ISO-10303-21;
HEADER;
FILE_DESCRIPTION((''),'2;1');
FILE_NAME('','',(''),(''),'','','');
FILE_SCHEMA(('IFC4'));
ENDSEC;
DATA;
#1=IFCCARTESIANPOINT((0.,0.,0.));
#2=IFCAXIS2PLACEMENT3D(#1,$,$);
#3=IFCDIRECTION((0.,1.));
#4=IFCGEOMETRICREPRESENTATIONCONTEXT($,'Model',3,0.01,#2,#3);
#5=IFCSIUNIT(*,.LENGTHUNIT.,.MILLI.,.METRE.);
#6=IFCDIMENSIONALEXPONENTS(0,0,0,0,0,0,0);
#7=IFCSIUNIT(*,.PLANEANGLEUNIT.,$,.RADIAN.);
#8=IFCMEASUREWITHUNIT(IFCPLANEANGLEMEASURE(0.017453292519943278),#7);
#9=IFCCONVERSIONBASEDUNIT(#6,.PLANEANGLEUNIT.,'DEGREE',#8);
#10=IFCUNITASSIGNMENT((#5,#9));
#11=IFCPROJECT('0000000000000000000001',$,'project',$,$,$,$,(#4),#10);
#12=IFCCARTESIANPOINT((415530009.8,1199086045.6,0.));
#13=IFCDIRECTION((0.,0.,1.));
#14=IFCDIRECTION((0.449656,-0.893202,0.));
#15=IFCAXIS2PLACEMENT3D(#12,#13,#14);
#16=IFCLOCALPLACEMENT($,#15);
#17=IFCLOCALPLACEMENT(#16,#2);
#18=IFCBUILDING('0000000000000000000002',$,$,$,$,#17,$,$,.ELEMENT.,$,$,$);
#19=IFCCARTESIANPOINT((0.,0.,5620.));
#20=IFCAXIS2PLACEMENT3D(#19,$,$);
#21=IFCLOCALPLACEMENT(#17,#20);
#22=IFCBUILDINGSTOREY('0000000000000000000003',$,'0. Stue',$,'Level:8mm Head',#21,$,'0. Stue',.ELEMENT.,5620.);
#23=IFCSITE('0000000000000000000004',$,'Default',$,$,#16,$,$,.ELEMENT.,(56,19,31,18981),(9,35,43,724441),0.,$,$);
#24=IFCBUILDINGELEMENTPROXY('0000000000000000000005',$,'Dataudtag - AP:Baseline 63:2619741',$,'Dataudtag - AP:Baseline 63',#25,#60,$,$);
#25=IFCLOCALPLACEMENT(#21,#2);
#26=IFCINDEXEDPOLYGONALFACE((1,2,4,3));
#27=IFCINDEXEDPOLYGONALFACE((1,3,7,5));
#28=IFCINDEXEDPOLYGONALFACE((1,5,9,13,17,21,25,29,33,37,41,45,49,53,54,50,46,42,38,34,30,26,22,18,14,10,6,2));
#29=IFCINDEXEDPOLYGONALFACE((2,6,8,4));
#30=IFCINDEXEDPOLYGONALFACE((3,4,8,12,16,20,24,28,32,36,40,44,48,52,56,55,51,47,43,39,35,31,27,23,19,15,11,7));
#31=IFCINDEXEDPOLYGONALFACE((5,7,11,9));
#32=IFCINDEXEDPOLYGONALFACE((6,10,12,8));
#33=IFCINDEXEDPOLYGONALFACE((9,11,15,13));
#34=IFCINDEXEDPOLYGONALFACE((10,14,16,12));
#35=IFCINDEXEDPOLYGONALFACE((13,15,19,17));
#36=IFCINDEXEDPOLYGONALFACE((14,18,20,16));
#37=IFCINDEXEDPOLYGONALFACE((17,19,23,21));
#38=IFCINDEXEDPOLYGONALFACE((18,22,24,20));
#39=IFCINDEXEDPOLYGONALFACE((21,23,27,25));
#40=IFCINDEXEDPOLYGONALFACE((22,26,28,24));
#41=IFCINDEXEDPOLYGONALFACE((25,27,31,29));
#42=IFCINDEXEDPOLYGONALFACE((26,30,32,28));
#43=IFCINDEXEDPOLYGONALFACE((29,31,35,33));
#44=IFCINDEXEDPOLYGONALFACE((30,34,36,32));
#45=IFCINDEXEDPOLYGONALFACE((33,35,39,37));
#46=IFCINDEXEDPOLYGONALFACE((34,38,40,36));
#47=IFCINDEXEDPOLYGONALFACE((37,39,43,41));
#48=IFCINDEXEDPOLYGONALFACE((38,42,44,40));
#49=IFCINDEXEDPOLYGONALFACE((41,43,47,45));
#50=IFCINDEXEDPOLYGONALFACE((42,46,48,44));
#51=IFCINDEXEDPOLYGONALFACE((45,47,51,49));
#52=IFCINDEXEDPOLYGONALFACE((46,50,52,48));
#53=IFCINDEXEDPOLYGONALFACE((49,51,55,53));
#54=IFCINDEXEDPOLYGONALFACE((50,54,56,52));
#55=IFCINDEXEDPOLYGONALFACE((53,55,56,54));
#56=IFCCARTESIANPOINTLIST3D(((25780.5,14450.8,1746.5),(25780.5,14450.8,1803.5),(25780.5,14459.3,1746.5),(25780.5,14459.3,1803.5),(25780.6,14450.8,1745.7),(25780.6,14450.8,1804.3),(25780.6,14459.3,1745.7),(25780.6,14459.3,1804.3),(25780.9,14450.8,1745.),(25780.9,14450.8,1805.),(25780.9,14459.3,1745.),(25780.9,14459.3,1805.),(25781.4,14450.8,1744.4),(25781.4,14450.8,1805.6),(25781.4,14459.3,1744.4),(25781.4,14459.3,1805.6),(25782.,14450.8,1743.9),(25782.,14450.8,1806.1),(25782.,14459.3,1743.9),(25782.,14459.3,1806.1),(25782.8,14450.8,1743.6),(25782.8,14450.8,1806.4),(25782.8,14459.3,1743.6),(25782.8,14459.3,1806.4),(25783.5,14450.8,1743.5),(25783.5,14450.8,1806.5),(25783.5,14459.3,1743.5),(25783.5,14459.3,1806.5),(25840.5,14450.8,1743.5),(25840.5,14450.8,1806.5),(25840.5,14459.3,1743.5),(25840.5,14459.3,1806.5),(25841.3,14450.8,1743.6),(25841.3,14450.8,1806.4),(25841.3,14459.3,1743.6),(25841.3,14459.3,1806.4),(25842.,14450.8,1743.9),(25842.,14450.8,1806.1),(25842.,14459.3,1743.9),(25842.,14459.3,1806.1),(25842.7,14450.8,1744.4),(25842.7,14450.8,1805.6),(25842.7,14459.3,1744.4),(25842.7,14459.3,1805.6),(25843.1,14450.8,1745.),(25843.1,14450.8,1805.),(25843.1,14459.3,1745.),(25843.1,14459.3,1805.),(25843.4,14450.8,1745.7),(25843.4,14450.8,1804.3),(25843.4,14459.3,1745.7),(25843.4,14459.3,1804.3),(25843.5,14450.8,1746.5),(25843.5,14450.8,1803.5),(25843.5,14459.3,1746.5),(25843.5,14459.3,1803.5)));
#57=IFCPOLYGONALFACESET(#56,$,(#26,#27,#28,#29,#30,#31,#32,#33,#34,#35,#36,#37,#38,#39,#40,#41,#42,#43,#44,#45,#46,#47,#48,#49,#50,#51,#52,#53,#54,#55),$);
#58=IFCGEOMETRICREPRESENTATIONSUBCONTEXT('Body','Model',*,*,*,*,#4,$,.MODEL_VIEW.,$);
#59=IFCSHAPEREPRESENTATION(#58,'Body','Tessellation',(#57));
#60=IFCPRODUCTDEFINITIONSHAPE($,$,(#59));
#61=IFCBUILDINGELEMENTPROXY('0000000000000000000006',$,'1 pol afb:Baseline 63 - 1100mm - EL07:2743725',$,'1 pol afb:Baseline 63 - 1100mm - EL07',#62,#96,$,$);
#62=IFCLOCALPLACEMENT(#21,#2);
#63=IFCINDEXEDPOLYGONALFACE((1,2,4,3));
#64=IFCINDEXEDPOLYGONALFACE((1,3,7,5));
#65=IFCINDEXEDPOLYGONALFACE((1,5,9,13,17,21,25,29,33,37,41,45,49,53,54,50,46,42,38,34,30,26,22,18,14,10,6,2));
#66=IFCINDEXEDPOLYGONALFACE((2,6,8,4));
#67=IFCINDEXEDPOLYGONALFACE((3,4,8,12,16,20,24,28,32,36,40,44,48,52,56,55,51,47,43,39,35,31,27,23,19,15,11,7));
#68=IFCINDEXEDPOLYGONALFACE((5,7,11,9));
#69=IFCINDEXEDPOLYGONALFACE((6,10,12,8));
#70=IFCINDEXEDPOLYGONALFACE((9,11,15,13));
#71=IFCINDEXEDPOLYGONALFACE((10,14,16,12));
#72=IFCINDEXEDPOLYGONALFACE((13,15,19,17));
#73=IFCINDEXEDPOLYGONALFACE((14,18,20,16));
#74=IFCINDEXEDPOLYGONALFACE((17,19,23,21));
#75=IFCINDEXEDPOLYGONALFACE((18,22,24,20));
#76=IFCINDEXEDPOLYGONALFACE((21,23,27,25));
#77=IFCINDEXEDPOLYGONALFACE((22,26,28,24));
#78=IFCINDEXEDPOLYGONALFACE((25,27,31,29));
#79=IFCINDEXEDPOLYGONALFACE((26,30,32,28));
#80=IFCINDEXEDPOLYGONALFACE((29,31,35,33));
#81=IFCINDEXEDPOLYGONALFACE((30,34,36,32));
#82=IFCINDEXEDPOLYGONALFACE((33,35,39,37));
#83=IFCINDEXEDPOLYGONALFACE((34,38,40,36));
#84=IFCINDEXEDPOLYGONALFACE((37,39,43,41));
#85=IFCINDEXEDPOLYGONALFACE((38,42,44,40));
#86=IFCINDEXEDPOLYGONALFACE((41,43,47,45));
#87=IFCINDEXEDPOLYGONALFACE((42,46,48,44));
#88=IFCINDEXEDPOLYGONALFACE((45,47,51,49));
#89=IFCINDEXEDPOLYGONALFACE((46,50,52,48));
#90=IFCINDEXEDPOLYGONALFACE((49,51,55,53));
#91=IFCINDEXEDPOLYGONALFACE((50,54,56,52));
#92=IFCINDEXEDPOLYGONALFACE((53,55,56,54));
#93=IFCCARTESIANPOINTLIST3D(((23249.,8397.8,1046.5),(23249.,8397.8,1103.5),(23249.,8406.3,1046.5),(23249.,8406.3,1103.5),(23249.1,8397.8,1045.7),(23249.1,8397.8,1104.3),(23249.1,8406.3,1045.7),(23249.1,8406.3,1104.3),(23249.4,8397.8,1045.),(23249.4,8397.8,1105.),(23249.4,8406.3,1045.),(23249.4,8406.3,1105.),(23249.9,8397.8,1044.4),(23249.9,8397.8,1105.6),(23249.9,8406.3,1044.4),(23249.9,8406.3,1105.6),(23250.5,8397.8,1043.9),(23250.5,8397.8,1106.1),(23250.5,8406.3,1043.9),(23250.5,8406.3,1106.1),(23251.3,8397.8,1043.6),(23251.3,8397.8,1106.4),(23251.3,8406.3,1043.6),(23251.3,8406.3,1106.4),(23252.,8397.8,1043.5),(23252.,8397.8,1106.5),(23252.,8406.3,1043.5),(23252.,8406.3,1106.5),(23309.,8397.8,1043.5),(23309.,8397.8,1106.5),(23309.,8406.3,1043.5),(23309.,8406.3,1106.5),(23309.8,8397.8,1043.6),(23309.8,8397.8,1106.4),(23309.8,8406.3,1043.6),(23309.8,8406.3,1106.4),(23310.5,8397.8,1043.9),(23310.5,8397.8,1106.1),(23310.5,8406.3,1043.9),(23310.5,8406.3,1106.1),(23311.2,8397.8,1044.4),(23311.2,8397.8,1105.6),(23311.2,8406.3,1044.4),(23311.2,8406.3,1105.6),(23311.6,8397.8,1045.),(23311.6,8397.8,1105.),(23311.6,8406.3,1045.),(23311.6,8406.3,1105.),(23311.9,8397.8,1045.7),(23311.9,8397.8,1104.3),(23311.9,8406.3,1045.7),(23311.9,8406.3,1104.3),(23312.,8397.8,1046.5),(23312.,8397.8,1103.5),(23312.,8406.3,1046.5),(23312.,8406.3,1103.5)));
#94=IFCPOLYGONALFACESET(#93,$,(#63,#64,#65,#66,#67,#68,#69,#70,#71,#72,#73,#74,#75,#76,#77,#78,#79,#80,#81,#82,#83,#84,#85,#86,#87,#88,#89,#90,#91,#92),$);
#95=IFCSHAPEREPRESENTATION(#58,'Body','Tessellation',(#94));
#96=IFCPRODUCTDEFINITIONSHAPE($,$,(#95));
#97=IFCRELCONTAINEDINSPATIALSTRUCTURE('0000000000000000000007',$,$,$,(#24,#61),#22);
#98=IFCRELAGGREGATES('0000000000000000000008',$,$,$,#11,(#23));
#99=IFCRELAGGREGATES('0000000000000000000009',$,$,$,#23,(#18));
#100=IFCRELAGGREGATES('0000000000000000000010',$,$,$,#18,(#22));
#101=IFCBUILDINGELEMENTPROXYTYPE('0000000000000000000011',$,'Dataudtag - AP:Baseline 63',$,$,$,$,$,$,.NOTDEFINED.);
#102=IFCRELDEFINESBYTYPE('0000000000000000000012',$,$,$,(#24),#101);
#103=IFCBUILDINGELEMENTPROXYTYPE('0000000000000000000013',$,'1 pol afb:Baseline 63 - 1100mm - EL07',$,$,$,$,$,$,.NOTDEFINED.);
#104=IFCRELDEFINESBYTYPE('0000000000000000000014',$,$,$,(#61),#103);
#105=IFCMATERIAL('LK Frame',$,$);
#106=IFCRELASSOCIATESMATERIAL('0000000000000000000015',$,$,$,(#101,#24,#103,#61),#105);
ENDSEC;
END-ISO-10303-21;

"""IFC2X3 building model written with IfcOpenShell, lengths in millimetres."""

from ifc_helpers import new_model, entity, si_unit, converted_unit, direction, frame, frame_2d, origin, place, context, subcontext, project, spatial, polyline, circle_curve, parameter, trimmed, segment, composite_curve, outline, extrude, source, transform, mapped, material, type_object, type_shapes, element, save


model = new_model("IFC2X3")

# Units and contexts
model_context = context("Model", 3, precision=0.01, world=origin(), true_north=direction((0.0, 1.0)))
body_context = subcontext(model_context, "Body", "Model", "MODEL_VIEW")
ifc_project = project(units=[si_unit("LENGTHUNIT", "METRE", prefix="MILLI"), converted_unit("PLANEANGLEUNIT", "DEGREE", entity("IfcPlaneAngleMeasure", 0.017453292519943278), si_unit("PLANEANGLEUNIT", "RADIAN"), dimensions=[0, 0, 0, 0, 0, 0, 0])], contexts=[model_context])

# Site, building, storey
site_placement = place(None, frame((415530009.8, 1199086045.6, 0.0), z_axis=(0.0, 0.0, 1.0), x_axis=(0.449656, -0.893202, 0.0)))
site = spatial("IfcSite", under=ifc_project, at=site_placement, Name="Default", CompositionType="ELEMENT", RefLatitude=(56, 19, 31, 18981), RefLongitude=(9, 35, 43, 724441), RefElevation=0.0)
building_placement = place(site_placement, origin())
building = spatial("IfcBuilding", under=site, at=building_placement, CompositionType="ELEMENT")
storey_placement = place(building_placement, frame((0.0, 0.0, 5620.0)))
storey = spatial("IfcBuildingStorey", under=building, at=storey_placement, Name="0. Stue", ObjectType="Level:8mm Head", LongName="0. Stue", CompositionType="ELEMENT", Elevation=5620.0)

# Building element proxies
ifc_material_1 = material(Name="LK Frame")
building_element_proxy_type_1 = type_object("IfcBuildingElementProxyType", Name="Dataudtag - AP:Baseline 63", PredefinedType="NOTDEFINED", material=ifc_material_1)
shared_shape_1 = source(origin(), body_context, "Body", "SweptSolid", [
    extrude(outline(composite_curve([segment(polyline([(-28.5, -31.5), (28.5, -31.5)]), True, "CONTINUOUS"), segment(trimmed(circle_curve(frame_2d((28.5, -28.5), x_axis=(-1.0, 0.0)), 3.0), [parameter(90.0)], [parameter(180.0)], True, "PARAMETER"), True, "CONTINUOUS"), segment(polyline([(31.5, -28.5), (31.5, 28.5)]), True, "CONTINUOUS"), segment(trimmed(circle_curve(frame_2d((28.5, 28.5), x_axis=(-1.0, 0.0)), 3.0), [parameter(180.0)], [parameter(270.0)], True, "PARAMETER"), True, "CONTINUOUS"), segment(polyline([(28.5, 31.5), (-28.5, 31.5)]), True, "CONTINUOUS"), segment(trimmed(circle_curve(frame_2d((-28.5, 28.5), x_axis=(1.0, 0.0)), 3.0), [parameter(90.0)], [parameter(180.0)], True, "PARAMETER"), True, "CONTINUOUS"), segment(polyline([(-31.5, 28.5), (-31.5, -28.5)]), True, "CONTINUOUS"), segment(trimmed(circle_curve(frame_2d((-28.5, -28.5), x_axis=(1.0, 0.0)), 3.0), [parameter(180.0)], [parameter(270.0)], True, "PARAMETER"), True, "CONTINUOUS")], self_intersect=False)), frame((0.0, -25.0, 0.0), z_axis=(0.0, 0.0, 1.0), x_axis=(0.0, 1.0, 0.0)), (0.0, 0.0, 1.0), 8.5),
])
type_shapes(building_element_proxy_type_1, [shared_shape_1])
proxy_1_placement = place(storey_placement, frame((25812.0, 14450.8, 1800.0), z_axis=(0.0, 1.0, 0.0), x_axis=(-1.0, 0.0, 0.0)))
element("IfcBuildingElementProxy", 1, at=proxy_1_placement, inside=storey, type_object=building_element_proxy_type_1, material=ifc_material_1, Name="Dataudtag - AP:Baseline 63:2619741", ObjectType="Dataudtag - AP:Baseline 63", context=body_context, shape_type="MappedRepresentation", body=[
    mapped(shared_shape_1, transform((0.0, 0.0, 0.0), scale=1.0)),
])
building_element_proxy_type_2 = type_object("IfcBuildingElementProxyType", Name="1 pol afb:Baseline 63 - 1100mm - EL07", PredefinedType="NOTDEFINED", material=ifc_material_1)
shared_shape_2 = source(origin(), body_context, "Body", "SweptSolid", [
    extrude(outline(composite_curve([segment(polyline([(-28.5, -31.5), (28.5, -31.5)]), True, "CONTINUOUS"), segment(trimmed(circle_curve(frame_2d((28.5, -28.5), x_axis=(-1.0, 0.0)), 3.0), [parameter(90.0)], [parameter(180.0)], True, "PARAMETER"), True, "CONTINUOUS"), segment(polyline([(31.5, -28.5), (31.5, 28.5)]), True, "CONTINUOUS"), segment(trimmed(circle_curve(frame_2d((28.5, 28.5), x_axis=(-1.0, 0.0)), 3.0), [parameter(180.0)], [parameter(270.0)], True, "PARAMETER"), True, "CONTINUOUS"), segment(polyline([(28.5, 31.5), (-28.5, 31.5)]), True, "CONTINUOUS"), segment(trimmed(circle_curve(frame_2d((-28.5, 28.5), x_axis=(1.0, 0.0)), 3.0), [parameter(90.0)], [parameter(180.0)], True, "PARAMETER"), True, "CONTINUOUS"), segment(polyline([(-31.5, 28.5), (-31.5, -28.5)]), True, "CONTINUOUS"), segment(trimmed(circle_curve(frame_2d((-28.5, -28.5), x_axis=(1.0, 0.0)), 3.0), [parameter(180.0)], [parameter(270.0)], True, "PARAMETER"), True, "CONTINUOUS")], self_intersect=False)), frame((0.0, -25.0, 0.0), z_axis=(0.0, 0.0, 1.0), x_axis=(0.0, 1.0, 0.0)), (0.0, 0.0, 1.0), 8.5),
])
type_shapes(building_element_proxy_type_2, [shared_shape_2])
proxy_2_placement = place(storey_placement, frame((23280.5, 8406.3, 1100.0), z_axis=(0.0, -1.0, 0.0), x_axis=(1.0, 0.0, 0.0)))
element("IfcBuildingElementProxy", 2, at=proxy_2_placement, inside=storey, type_object=building_element_proxy_type_2, material=ifc_material_1, Name="1 pol afb:Baseline 63 - 1100mm - EL07:2743725", ObjectType="1 pol afb:Baseline 63 - 1100mm - EL07", context=body_context, shape_type="MappedRepresentation", body=[
    mapped(shared_shape_2, transform((0.0, 0.0, 0.0), scale=1.0)),
])

save(model, "model.ifc")
